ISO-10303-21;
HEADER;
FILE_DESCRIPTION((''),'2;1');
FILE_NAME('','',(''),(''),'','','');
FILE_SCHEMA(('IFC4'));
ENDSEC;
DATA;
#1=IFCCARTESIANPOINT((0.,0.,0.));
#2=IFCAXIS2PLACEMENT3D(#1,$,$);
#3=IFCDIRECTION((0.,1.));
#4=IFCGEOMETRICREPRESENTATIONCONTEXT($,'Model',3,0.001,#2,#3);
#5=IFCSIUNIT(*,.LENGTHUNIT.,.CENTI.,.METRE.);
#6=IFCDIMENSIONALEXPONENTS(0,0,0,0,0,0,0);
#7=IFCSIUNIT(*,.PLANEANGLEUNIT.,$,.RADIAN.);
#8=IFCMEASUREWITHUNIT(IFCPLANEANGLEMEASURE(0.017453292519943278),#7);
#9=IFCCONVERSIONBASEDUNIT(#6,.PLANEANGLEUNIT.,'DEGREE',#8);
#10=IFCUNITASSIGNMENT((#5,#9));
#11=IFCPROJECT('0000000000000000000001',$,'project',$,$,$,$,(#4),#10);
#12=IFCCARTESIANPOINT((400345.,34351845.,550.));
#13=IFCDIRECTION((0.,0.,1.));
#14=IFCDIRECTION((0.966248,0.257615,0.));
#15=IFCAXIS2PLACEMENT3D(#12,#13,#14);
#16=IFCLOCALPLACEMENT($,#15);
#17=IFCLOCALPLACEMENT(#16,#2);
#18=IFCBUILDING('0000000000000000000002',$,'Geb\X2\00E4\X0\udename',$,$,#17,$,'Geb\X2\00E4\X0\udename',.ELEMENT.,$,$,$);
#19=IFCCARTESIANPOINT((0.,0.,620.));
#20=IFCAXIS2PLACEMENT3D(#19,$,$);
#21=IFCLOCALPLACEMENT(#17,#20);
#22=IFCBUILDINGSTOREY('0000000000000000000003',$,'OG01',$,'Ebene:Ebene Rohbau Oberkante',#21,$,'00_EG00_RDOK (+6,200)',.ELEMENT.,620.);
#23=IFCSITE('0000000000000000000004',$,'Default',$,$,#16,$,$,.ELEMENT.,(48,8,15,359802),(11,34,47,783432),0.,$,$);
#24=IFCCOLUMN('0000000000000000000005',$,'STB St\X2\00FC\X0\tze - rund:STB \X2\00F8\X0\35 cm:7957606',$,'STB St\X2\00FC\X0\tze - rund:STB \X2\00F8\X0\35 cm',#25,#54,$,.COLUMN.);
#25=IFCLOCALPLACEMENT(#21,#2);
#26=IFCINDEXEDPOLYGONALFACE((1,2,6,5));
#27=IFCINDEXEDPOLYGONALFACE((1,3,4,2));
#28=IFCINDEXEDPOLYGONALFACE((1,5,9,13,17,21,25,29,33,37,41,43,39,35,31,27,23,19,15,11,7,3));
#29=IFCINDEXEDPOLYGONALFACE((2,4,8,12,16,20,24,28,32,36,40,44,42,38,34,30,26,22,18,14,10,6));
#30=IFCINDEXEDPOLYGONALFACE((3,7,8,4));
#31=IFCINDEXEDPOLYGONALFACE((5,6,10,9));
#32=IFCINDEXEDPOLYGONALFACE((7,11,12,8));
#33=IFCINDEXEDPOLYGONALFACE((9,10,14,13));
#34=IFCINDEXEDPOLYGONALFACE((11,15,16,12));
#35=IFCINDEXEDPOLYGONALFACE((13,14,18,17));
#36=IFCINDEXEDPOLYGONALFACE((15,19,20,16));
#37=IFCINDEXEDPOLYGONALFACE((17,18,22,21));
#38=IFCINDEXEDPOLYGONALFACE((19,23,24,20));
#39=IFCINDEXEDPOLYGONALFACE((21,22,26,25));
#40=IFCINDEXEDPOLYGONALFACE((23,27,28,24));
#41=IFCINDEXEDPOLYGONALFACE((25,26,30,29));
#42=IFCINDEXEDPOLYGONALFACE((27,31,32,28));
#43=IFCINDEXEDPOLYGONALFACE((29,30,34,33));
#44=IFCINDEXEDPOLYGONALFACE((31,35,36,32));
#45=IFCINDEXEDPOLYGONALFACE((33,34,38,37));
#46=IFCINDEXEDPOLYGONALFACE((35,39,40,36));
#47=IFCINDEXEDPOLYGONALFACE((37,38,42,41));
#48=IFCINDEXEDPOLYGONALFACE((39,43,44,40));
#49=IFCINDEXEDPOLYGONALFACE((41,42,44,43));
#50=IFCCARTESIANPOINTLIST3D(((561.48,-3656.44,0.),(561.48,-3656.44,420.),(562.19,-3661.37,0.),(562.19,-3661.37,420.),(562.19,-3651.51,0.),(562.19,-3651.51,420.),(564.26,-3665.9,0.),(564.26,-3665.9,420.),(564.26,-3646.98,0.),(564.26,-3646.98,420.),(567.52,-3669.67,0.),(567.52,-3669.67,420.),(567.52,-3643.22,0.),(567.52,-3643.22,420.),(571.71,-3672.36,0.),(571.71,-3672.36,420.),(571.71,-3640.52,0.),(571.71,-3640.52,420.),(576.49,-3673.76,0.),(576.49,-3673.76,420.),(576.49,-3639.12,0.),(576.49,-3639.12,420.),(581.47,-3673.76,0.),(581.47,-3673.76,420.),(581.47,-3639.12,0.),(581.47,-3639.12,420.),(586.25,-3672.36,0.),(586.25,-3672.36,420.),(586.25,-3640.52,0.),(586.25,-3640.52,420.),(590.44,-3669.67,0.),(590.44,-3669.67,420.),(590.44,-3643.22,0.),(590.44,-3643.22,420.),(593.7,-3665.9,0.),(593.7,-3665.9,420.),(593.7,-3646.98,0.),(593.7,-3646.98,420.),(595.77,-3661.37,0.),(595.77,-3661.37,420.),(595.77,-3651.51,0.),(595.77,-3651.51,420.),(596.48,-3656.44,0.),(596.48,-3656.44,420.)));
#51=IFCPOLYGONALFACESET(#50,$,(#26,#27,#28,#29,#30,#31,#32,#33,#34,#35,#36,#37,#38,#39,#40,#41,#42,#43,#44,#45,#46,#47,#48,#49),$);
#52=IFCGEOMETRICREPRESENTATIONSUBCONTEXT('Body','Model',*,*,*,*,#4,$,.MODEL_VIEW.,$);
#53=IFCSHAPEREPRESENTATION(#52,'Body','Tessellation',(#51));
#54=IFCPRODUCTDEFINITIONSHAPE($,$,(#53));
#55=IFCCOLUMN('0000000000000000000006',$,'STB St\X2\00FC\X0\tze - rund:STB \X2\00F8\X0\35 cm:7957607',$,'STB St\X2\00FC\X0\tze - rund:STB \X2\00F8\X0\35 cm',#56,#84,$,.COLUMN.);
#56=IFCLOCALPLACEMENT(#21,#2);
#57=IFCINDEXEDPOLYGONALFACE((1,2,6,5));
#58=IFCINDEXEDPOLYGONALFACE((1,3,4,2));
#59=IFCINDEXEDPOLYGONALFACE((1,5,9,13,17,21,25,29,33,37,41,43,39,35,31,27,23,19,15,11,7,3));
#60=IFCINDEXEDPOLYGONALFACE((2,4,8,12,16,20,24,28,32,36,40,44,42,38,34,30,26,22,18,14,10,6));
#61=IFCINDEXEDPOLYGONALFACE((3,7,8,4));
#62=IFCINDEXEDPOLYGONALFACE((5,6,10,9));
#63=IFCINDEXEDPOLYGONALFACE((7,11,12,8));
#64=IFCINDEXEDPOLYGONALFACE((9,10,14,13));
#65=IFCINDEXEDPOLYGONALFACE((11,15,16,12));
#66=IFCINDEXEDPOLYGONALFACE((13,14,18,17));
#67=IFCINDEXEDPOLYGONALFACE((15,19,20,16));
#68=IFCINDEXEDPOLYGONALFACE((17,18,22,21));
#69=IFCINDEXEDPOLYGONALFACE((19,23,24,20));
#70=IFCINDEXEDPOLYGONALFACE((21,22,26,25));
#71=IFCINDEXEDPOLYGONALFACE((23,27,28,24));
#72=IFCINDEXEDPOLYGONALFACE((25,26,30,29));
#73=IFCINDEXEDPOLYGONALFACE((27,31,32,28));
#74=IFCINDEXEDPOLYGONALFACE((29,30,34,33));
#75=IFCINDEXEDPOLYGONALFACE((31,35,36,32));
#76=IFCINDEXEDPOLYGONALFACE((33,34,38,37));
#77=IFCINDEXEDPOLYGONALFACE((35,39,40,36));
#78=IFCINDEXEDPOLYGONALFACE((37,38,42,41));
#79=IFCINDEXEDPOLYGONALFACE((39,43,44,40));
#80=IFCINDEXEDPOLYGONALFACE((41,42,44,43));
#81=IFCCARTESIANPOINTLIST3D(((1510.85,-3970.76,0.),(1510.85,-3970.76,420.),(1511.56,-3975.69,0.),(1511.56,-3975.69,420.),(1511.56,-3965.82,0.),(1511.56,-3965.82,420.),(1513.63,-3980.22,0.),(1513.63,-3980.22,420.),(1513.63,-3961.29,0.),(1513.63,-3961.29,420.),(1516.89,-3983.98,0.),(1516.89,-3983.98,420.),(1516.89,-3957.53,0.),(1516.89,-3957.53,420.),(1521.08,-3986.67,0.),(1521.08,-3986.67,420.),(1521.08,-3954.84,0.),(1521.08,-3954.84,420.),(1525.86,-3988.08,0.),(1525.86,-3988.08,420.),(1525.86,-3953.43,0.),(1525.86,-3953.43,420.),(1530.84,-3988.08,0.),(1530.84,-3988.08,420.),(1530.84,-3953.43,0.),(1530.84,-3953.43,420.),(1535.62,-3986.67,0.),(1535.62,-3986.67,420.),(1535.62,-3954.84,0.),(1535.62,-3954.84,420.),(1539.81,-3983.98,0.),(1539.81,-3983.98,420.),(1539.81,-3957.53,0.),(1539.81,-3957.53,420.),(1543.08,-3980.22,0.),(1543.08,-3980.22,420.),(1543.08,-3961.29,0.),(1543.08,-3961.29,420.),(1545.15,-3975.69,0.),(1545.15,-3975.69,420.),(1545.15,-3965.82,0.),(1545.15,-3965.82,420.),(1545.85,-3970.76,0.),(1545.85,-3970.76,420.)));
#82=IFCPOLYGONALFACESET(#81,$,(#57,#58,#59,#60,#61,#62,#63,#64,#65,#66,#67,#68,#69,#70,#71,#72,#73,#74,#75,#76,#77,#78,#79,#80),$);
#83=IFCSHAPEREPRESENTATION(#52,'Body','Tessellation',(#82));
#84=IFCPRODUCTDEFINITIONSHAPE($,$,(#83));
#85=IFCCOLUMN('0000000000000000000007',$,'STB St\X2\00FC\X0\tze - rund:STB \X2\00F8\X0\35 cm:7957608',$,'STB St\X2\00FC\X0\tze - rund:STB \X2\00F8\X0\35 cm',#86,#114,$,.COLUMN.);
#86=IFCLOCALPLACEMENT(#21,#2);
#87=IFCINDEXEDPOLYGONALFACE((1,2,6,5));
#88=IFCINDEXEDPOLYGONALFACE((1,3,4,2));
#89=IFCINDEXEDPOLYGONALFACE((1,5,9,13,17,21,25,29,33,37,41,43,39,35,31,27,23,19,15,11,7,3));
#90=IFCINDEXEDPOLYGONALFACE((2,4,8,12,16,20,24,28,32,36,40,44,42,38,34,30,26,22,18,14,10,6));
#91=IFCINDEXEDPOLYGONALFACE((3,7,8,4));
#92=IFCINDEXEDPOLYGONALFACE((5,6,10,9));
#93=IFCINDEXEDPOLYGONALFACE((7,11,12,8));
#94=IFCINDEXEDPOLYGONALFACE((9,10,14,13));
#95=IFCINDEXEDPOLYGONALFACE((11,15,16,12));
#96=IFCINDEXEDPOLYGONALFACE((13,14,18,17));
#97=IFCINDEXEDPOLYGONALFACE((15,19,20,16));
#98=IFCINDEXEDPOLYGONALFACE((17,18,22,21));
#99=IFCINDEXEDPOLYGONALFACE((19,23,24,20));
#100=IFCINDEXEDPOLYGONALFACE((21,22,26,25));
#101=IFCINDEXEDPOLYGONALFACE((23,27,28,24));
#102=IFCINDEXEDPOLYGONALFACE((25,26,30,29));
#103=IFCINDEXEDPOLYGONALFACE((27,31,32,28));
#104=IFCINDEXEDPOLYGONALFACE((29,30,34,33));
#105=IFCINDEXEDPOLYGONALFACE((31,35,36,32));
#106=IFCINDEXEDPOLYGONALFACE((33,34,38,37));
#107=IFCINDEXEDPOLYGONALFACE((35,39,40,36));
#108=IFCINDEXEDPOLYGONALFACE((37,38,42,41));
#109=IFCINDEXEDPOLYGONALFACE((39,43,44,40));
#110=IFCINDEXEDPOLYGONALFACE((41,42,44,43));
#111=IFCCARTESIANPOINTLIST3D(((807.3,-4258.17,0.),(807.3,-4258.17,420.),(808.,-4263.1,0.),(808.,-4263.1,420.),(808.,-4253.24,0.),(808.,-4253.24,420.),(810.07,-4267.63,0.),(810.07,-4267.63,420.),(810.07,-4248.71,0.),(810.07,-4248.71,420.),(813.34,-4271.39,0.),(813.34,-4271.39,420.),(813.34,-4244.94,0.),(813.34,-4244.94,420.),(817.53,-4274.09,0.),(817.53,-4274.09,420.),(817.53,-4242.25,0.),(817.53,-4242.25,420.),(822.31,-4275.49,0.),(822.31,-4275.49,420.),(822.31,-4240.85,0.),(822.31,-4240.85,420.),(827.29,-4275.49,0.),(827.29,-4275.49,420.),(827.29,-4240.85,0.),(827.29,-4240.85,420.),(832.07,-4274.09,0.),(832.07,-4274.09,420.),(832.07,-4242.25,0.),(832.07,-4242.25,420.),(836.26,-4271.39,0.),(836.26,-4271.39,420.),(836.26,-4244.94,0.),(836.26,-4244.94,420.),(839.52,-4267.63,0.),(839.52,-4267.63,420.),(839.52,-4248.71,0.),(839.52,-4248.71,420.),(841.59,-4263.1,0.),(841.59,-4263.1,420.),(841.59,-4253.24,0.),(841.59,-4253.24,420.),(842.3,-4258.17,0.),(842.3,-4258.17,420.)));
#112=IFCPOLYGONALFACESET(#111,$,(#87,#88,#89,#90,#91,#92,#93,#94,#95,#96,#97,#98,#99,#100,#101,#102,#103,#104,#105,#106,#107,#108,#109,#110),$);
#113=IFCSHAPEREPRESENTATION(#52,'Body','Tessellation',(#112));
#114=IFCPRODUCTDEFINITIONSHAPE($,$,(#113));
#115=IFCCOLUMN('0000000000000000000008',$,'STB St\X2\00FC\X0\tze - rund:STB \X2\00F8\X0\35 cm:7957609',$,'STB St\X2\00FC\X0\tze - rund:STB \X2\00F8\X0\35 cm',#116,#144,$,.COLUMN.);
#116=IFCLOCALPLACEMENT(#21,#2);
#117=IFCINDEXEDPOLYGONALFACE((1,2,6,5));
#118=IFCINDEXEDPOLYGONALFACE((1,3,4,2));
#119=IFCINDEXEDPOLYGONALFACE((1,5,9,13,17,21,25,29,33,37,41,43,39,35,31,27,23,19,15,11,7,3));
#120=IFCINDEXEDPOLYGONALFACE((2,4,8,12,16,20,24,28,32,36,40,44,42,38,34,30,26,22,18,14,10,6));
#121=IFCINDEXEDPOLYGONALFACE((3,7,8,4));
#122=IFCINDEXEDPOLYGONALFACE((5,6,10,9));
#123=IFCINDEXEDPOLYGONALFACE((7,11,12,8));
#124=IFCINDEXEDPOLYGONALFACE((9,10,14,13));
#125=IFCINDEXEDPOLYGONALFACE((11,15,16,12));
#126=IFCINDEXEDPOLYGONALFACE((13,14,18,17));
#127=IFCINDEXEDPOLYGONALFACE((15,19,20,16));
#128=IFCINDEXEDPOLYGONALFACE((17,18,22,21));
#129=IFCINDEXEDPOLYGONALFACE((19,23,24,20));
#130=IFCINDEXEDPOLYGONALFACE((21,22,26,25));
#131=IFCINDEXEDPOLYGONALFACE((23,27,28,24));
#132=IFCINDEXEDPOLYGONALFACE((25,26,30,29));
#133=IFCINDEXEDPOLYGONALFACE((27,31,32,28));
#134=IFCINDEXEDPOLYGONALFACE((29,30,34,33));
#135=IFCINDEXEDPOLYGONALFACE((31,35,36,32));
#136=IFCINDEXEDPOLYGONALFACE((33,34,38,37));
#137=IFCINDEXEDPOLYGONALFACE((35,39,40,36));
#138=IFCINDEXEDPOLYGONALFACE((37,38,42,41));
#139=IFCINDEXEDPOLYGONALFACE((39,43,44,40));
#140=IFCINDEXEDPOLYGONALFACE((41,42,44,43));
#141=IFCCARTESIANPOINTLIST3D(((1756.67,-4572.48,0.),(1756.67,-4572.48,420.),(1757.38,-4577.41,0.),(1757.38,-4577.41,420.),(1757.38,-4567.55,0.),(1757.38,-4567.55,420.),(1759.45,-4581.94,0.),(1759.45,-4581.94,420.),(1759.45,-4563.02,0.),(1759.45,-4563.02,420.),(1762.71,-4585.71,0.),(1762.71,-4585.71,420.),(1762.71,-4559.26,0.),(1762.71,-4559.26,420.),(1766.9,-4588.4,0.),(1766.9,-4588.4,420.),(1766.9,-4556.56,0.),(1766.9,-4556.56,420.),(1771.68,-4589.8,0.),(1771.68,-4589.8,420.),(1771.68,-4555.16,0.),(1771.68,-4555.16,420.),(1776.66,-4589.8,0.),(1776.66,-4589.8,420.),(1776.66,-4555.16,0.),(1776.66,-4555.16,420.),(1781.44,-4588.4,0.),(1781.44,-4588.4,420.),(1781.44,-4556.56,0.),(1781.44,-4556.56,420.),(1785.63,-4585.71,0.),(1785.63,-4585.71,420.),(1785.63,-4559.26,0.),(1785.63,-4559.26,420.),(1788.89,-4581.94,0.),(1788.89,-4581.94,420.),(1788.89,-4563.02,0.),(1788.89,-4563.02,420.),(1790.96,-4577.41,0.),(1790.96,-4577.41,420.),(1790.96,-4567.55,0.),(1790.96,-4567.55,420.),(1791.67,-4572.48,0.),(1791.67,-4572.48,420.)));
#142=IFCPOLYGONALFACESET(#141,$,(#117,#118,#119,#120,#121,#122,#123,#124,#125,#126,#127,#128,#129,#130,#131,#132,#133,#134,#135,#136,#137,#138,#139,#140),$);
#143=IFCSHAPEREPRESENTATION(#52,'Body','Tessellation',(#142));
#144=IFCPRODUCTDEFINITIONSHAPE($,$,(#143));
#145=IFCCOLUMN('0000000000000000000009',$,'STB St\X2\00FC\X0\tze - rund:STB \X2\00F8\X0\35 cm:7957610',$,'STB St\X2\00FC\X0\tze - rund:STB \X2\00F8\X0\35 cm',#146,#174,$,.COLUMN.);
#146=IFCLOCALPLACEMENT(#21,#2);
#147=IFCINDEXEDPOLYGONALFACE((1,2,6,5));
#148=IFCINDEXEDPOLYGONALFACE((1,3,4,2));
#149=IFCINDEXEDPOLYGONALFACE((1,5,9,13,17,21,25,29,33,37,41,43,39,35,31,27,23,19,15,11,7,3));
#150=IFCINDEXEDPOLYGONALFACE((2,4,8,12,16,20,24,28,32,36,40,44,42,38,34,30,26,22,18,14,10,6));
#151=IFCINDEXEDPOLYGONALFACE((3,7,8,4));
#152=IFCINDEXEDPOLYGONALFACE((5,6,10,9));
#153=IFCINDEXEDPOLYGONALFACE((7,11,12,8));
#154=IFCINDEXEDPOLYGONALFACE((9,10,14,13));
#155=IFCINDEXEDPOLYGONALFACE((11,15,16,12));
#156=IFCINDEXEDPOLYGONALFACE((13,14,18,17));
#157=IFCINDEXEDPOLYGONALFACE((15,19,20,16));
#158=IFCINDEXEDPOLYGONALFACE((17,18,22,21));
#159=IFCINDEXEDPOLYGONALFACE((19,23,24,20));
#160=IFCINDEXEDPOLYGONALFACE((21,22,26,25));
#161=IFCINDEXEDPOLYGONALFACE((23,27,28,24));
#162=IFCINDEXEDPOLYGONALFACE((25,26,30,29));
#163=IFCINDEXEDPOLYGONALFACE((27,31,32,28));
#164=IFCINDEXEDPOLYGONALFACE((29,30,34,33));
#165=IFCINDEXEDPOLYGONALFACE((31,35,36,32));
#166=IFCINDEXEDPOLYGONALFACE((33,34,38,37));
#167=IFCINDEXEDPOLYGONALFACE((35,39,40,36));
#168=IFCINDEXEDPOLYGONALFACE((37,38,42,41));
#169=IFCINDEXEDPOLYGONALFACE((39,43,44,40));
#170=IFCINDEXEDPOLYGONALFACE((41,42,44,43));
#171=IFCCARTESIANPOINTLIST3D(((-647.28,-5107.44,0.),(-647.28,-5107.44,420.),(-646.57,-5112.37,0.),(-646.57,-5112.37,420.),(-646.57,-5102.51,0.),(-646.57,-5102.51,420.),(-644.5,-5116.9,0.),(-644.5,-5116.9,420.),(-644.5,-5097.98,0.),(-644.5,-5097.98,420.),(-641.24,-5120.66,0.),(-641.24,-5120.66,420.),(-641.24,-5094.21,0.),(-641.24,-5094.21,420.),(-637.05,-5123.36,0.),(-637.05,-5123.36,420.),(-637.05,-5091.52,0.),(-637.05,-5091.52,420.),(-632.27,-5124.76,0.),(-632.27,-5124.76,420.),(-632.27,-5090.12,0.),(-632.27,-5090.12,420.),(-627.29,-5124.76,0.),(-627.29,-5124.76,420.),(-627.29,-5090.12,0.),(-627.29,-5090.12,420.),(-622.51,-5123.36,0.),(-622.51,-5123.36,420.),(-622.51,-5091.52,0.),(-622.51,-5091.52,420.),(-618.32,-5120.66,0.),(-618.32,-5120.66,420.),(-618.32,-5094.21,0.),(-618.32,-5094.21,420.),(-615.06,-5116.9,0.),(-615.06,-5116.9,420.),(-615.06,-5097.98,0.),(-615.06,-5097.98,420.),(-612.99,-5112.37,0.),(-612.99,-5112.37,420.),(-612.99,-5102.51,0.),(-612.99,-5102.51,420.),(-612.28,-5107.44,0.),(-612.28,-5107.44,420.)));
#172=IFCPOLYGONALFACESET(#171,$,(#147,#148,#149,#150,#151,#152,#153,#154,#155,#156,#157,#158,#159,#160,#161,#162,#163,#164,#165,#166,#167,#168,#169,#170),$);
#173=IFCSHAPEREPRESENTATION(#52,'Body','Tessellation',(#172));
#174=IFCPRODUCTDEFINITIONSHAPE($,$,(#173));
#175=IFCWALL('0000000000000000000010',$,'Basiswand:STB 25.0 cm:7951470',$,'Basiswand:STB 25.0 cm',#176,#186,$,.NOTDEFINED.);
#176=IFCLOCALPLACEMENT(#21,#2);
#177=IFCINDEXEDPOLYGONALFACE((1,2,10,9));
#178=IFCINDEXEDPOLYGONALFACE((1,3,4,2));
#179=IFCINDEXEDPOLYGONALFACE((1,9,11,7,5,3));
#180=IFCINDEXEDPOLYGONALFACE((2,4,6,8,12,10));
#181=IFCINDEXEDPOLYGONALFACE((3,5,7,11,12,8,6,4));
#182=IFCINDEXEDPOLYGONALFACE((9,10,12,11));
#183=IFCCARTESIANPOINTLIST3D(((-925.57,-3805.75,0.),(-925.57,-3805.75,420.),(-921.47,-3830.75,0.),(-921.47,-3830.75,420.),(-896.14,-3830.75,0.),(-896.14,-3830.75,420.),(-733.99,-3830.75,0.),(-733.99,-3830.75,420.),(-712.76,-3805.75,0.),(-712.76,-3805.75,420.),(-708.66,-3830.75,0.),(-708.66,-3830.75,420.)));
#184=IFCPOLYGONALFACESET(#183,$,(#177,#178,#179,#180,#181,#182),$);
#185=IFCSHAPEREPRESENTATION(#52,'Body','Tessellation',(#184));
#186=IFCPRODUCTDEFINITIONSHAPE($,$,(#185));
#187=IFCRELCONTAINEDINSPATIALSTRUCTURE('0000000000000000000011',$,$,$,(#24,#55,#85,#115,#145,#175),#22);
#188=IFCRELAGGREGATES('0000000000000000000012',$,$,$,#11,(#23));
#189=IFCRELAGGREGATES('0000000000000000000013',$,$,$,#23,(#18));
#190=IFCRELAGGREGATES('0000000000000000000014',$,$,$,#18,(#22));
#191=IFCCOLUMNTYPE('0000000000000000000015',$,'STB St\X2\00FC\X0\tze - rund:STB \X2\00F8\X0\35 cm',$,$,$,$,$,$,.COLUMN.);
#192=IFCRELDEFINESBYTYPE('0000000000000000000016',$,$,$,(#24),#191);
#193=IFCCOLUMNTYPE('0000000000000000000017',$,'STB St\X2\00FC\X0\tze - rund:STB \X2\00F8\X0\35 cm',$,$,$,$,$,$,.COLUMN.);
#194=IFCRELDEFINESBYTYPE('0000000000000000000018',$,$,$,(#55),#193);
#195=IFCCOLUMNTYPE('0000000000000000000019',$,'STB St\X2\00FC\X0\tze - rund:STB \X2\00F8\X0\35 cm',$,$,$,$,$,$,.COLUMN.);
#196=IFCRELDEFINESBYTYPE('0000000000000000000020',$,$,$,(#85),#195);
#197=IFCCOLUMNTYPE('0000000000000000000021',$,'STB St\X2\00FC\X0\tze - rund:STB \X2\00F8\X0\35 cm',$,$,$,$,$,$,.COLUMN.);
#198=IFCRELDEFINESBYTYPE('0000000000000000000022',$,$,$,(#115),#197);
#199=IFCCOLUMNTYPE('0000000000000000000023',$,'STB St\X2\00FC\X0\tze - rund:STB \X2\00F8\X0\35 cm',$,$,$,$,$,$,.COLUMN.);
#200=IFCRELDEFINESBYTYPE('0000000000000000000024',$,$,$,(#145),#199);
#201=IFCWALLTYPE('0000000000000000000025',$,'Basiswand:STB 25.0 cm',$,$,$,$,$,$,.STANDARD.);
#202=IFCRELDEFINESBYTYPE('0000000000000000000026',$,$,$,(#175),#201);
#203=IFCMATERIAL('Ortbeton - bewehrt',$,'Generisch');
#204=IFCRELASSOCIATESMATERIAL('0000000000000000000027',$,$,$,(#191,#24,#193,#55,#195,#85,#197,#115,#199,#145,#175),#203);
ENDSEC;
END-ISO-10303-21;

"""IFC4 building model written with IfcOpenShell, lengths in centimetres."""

from ifc_helpers import new_model, entity, si_unit, converted_unit, direction, frame, origin, place, context, subcontext, project, spatial, arc, indexed_curve, outline, extrude, source, transform, mapped, material, type_object, type_shapes, element, save


model = new_model("IFC4")

# Units and contexts
model_context = context("Model", 3, precision=0.001, world=origin(), true_north=direction((0.0, 1.0)))
body_context = subcontext(model_context, "Body", "Model", "MODEL_VIEW")
ifc_project = project(units=[si_unit("LENGTHUNIT", "METRE", prefix="CENTI"), converted_unit("PLANEANGLEUNIT", "DEGREE", entity("IfcPlaneAngleMeasure", 0.017453292519943278), si_unit("PLANEANGLEUNIT", "RADIAN"), dimensions=[0, 0, 0, 0, 0, 0, 0])], contexts=[model_context])

# Site, building, storey
site_placement = place(None, frame((400345.0, 34351845.0, 550.0), z_axis=(0.0, 0.0, 1.0), x_axis=(0.966248, 0.257615, 0.0)))
site = spatial("IfcSite", under=ifc_project, at=site_placement, Name="Default", CompositionType="ELEMENT", RefLatitude=(48, 8, 15, 359802), RefLongitude=(11, 34, 47, 783432), RefElevation=0.0)
building_placement = place(site_placement, origin())
building = spatial("IfcBuilding", under=site, at=building_placement, Name="Gebäudename", LongName="Gebäudename", CompositionType="ELEMENT")
storey_placement = place(building_placement, frame((0.0, 0.0, 620.0)))
storey = spatial("IfcBuildingStorey", under=building, at=storey_placement, Name="OG01", ObjectType="Ebene:Ebene Rohbau Oberkante", LongName="00_EG00_RDOK (+6,200)", CompositionType="ELEMENT", Elevation=620.0)

# Columns
ifc_material = material(Name="Ortbeton - bewehrt", Category="Generisch")
column_type_1 = type_object("IfcColumnType", Name="STB Stütze - rund:STB ø35 cm", PredefinedType="COLUMN", material=ifc_material)
shared_shape_1 = source(origin(), body_context, "Body", "SweptSolid", [
    extrude(outline(indexed_curve([(-17.5, 0.0), (0.0, -17.5), (17.5, 0.0), (0.0, 17.5)], segments=[arc(1, 2, 3), arc(3, 4, 1)], self_intersect=False)), frame((578.98, -3656.44, 620.0)), (0.0, 0.0, 1.0), 420.0),
])
type_shapes(column_type_1, [shared_shape_1])
column_1_placement = place(storey_placement, frame((0.0, 0.0, -620.0)))
element("IfcColumn", 1, at=column_1_placement, inside=storey, type_object=column_type_1, material=ifc_material, Name="STB Stütze - rund:STB ø35 cm:7957606", ObjectType="STB Stütze - rund:STB ø35 cm", PredefinedType="COLUMN", context=body_context, shape_type="MappedRepresentation", body=[
    mapped(shared_shape_1, transform((0.0, 0.0, 0.0), scale=1.0)),
])
column_type_2 = type_object("IfcColumnType", Name="STB Stütze - rund:STB ø35 cm", PredefinedType="COLUMN", material=ifc_material)
shared_shape_2 = source(origin(), body_context, "Body", "SweptSolid", [
    extrude(outline(indexed_curve([(-17.5, 0.0), (0.0, -17.5), (17.5, 0.0), (0.0, 17.5)], segments=[arc(1, 2, 3), arc(3, 4, 1)], self_intersect=False)), frame((1528.35, -3970.76, 620.0)), (0.0, 0.0, 1.0), 420.0),
])
type_shapes(column_type_2, [shared_shape_2])
column_2_placement = place(storey_placement, frame((0.0, 0.0, -620.0)))
element("IfcColumn", 2, at=column_2_placement, inside=storey, type_object=column_type_2, material=ifc_material, Name="STB Stütze - rund:STB ø35 cm:7957607", ObjectType="STB Stütze - rund:STB ø35 cm", PredefinedType="COLUMN", context=body_context, shape_type="MappedRepresentation", body=[
    mapped(shared_shape_2, transform((0.0, 0.0, 0.0), scale=1.0)),
])
column_type_3 = type_object("IfcColumnType", Name="STB Stütze - rund:STB ø35 cm", PredefinedType="COLUMN", material=ifc_material)
shared_shape_3 = source(origin(), body_context, "Body", "SweptSolid", [
    extrude(outline(indexed_curve([(-17.5, 0.0), (0.0, -17.5), (17.5, 0.0), (0.0, 17.5)], segments=[arc(1, 2, 3), arc(3, 4, 1)], self_intersect=False)), frame((824.8, -4258.17, 620.0)), (0.0, 0.0, 1.0), 420.0),
])
type_shapes(column_type_3, [shared_shape_3])
column_3_placement = place(storey_placement, frame((0.0, 0.0, -620.0)))
element("IfcColumn", 3, at=column_3_placement, inside=storey, type_object=column_type_3, material=ifc_material, Name="STB Stütze - rund:STB ø35 cm:7957608", ObjectType="STB Stütze - rund:STB ø35 cm", PredefinedType="COLUMN", context=body_context, shape_type="MappedRepresentation", body=[
    mapped(shared_shape_3, transform((0.0, 0.0, 0.0), scale=1.0)),
])
column_type_4 = type_object("IfcColumnType", Name="STB Stütze - rund:STB ø35 cm", PredefinedType="COLUMN", material=ifc_material)
shared_shape_4 = source(origin(), body_context, "Body", "SweptSolid", [
    extrude(outline(indexed_curve([(-17.5, 0.0), (0.0, -17.5), (17.5, 0.0), (0.0, 17.5)], segments=[arc(1, 2, 3), arc(3, 4, 1)], self_intersect=False)), frame((1774.17, -4572.48, 620.0)), (0.0, 0.0, 1.0), 420.0),
])
type_shapes(column_type_4, [shared_shape_4])
column_4_placement = place(storey_placement, frame((0.0, 0.0, -620.0)))
element("IfcColumn", 4, at=column_4_placement, inside=storey, type_object=column_type_4, material=ifc_material, Name="STB Stütze - rund:STB ø35 cm:7957609", ObjectType="STB Stütze - rund:STB ø35 cm", PredefinedType="COLUMN", context=body_context, shape_type="MappedRepresentation", body=[
    mapped(shared_shape_4, transform((0.0, 0.0, 0.0), scale=1.0)),
])
column_type_5 = type_object("IfcColumnType", Name="STB Stütze - rund:STB ø35 cm", PredefinedType="COLUMN", material=ifc_material)
shared_shape_5 = source(origin(), body_context, "Body", "SweptSolid", [
    extrude(outline(indexed_curve([(-17.5, 0.0), (0.0, -17.5), (17.5, 0.0), (0.0, 17.5)], segments=[arc(1, 2, 3), arc(3, 4, 1)], self_intersect=False)), frame((-629.78, -5107.44, 620.0)), (0.0, 0.0, 1.0), 420.0),
])
type_shapes(column_type_5, [shared_shape_5])
column_5_placement = place(storey_placement, frame((0.0, 0.0, -620.0)))
element("IfcColumn", 5, at=column_5_placement, inside=storey, type_object=column_type_5, material=ifc_material, Name="STB Stütze - rund:STB ø35 cm:7957610", ObjectType="STB Stütze - rund:STB ø35 cm", PredefinedType="COLUMN", context=body_context, shape_type="MappedRepresentation", body=[
    mapped(shared_shape_5, transform((0.0, 0.0, 0.0), scale=1.0)),
])

# Wall
wall_type = type_object("IfcWallType", Name="Basiswand:STB 25.0 cm", PredefinedType="STANDARD")
wall_1_placement = place(storey_placement, frame((-925.57, -3818.25, 0.0)))
element("IfcWall", 6, at=wall_1_placement, inside=storey, type_object=wall_type, material=ifc_material, Name="Basiswand:STB 25.0 cm:7951470", ObjectType="Basiswand:STB 25.0 cm", PredefinedType="NOTDEFINED", context=body_context, shape_type="SweptSolid", body=[
    extrude(outline(indexed_curve([(216.92, -12.5), (212.81, 12.5), (0.0, 12.5), (4.1, -12.5), (29.44, -12.5), (191.58, -12.5), (216.92, -12.5)], self_intersect=False)), origin(), (0.0, 0.0, 1.0), 420.0),
])

save(model, "model.ifc")
